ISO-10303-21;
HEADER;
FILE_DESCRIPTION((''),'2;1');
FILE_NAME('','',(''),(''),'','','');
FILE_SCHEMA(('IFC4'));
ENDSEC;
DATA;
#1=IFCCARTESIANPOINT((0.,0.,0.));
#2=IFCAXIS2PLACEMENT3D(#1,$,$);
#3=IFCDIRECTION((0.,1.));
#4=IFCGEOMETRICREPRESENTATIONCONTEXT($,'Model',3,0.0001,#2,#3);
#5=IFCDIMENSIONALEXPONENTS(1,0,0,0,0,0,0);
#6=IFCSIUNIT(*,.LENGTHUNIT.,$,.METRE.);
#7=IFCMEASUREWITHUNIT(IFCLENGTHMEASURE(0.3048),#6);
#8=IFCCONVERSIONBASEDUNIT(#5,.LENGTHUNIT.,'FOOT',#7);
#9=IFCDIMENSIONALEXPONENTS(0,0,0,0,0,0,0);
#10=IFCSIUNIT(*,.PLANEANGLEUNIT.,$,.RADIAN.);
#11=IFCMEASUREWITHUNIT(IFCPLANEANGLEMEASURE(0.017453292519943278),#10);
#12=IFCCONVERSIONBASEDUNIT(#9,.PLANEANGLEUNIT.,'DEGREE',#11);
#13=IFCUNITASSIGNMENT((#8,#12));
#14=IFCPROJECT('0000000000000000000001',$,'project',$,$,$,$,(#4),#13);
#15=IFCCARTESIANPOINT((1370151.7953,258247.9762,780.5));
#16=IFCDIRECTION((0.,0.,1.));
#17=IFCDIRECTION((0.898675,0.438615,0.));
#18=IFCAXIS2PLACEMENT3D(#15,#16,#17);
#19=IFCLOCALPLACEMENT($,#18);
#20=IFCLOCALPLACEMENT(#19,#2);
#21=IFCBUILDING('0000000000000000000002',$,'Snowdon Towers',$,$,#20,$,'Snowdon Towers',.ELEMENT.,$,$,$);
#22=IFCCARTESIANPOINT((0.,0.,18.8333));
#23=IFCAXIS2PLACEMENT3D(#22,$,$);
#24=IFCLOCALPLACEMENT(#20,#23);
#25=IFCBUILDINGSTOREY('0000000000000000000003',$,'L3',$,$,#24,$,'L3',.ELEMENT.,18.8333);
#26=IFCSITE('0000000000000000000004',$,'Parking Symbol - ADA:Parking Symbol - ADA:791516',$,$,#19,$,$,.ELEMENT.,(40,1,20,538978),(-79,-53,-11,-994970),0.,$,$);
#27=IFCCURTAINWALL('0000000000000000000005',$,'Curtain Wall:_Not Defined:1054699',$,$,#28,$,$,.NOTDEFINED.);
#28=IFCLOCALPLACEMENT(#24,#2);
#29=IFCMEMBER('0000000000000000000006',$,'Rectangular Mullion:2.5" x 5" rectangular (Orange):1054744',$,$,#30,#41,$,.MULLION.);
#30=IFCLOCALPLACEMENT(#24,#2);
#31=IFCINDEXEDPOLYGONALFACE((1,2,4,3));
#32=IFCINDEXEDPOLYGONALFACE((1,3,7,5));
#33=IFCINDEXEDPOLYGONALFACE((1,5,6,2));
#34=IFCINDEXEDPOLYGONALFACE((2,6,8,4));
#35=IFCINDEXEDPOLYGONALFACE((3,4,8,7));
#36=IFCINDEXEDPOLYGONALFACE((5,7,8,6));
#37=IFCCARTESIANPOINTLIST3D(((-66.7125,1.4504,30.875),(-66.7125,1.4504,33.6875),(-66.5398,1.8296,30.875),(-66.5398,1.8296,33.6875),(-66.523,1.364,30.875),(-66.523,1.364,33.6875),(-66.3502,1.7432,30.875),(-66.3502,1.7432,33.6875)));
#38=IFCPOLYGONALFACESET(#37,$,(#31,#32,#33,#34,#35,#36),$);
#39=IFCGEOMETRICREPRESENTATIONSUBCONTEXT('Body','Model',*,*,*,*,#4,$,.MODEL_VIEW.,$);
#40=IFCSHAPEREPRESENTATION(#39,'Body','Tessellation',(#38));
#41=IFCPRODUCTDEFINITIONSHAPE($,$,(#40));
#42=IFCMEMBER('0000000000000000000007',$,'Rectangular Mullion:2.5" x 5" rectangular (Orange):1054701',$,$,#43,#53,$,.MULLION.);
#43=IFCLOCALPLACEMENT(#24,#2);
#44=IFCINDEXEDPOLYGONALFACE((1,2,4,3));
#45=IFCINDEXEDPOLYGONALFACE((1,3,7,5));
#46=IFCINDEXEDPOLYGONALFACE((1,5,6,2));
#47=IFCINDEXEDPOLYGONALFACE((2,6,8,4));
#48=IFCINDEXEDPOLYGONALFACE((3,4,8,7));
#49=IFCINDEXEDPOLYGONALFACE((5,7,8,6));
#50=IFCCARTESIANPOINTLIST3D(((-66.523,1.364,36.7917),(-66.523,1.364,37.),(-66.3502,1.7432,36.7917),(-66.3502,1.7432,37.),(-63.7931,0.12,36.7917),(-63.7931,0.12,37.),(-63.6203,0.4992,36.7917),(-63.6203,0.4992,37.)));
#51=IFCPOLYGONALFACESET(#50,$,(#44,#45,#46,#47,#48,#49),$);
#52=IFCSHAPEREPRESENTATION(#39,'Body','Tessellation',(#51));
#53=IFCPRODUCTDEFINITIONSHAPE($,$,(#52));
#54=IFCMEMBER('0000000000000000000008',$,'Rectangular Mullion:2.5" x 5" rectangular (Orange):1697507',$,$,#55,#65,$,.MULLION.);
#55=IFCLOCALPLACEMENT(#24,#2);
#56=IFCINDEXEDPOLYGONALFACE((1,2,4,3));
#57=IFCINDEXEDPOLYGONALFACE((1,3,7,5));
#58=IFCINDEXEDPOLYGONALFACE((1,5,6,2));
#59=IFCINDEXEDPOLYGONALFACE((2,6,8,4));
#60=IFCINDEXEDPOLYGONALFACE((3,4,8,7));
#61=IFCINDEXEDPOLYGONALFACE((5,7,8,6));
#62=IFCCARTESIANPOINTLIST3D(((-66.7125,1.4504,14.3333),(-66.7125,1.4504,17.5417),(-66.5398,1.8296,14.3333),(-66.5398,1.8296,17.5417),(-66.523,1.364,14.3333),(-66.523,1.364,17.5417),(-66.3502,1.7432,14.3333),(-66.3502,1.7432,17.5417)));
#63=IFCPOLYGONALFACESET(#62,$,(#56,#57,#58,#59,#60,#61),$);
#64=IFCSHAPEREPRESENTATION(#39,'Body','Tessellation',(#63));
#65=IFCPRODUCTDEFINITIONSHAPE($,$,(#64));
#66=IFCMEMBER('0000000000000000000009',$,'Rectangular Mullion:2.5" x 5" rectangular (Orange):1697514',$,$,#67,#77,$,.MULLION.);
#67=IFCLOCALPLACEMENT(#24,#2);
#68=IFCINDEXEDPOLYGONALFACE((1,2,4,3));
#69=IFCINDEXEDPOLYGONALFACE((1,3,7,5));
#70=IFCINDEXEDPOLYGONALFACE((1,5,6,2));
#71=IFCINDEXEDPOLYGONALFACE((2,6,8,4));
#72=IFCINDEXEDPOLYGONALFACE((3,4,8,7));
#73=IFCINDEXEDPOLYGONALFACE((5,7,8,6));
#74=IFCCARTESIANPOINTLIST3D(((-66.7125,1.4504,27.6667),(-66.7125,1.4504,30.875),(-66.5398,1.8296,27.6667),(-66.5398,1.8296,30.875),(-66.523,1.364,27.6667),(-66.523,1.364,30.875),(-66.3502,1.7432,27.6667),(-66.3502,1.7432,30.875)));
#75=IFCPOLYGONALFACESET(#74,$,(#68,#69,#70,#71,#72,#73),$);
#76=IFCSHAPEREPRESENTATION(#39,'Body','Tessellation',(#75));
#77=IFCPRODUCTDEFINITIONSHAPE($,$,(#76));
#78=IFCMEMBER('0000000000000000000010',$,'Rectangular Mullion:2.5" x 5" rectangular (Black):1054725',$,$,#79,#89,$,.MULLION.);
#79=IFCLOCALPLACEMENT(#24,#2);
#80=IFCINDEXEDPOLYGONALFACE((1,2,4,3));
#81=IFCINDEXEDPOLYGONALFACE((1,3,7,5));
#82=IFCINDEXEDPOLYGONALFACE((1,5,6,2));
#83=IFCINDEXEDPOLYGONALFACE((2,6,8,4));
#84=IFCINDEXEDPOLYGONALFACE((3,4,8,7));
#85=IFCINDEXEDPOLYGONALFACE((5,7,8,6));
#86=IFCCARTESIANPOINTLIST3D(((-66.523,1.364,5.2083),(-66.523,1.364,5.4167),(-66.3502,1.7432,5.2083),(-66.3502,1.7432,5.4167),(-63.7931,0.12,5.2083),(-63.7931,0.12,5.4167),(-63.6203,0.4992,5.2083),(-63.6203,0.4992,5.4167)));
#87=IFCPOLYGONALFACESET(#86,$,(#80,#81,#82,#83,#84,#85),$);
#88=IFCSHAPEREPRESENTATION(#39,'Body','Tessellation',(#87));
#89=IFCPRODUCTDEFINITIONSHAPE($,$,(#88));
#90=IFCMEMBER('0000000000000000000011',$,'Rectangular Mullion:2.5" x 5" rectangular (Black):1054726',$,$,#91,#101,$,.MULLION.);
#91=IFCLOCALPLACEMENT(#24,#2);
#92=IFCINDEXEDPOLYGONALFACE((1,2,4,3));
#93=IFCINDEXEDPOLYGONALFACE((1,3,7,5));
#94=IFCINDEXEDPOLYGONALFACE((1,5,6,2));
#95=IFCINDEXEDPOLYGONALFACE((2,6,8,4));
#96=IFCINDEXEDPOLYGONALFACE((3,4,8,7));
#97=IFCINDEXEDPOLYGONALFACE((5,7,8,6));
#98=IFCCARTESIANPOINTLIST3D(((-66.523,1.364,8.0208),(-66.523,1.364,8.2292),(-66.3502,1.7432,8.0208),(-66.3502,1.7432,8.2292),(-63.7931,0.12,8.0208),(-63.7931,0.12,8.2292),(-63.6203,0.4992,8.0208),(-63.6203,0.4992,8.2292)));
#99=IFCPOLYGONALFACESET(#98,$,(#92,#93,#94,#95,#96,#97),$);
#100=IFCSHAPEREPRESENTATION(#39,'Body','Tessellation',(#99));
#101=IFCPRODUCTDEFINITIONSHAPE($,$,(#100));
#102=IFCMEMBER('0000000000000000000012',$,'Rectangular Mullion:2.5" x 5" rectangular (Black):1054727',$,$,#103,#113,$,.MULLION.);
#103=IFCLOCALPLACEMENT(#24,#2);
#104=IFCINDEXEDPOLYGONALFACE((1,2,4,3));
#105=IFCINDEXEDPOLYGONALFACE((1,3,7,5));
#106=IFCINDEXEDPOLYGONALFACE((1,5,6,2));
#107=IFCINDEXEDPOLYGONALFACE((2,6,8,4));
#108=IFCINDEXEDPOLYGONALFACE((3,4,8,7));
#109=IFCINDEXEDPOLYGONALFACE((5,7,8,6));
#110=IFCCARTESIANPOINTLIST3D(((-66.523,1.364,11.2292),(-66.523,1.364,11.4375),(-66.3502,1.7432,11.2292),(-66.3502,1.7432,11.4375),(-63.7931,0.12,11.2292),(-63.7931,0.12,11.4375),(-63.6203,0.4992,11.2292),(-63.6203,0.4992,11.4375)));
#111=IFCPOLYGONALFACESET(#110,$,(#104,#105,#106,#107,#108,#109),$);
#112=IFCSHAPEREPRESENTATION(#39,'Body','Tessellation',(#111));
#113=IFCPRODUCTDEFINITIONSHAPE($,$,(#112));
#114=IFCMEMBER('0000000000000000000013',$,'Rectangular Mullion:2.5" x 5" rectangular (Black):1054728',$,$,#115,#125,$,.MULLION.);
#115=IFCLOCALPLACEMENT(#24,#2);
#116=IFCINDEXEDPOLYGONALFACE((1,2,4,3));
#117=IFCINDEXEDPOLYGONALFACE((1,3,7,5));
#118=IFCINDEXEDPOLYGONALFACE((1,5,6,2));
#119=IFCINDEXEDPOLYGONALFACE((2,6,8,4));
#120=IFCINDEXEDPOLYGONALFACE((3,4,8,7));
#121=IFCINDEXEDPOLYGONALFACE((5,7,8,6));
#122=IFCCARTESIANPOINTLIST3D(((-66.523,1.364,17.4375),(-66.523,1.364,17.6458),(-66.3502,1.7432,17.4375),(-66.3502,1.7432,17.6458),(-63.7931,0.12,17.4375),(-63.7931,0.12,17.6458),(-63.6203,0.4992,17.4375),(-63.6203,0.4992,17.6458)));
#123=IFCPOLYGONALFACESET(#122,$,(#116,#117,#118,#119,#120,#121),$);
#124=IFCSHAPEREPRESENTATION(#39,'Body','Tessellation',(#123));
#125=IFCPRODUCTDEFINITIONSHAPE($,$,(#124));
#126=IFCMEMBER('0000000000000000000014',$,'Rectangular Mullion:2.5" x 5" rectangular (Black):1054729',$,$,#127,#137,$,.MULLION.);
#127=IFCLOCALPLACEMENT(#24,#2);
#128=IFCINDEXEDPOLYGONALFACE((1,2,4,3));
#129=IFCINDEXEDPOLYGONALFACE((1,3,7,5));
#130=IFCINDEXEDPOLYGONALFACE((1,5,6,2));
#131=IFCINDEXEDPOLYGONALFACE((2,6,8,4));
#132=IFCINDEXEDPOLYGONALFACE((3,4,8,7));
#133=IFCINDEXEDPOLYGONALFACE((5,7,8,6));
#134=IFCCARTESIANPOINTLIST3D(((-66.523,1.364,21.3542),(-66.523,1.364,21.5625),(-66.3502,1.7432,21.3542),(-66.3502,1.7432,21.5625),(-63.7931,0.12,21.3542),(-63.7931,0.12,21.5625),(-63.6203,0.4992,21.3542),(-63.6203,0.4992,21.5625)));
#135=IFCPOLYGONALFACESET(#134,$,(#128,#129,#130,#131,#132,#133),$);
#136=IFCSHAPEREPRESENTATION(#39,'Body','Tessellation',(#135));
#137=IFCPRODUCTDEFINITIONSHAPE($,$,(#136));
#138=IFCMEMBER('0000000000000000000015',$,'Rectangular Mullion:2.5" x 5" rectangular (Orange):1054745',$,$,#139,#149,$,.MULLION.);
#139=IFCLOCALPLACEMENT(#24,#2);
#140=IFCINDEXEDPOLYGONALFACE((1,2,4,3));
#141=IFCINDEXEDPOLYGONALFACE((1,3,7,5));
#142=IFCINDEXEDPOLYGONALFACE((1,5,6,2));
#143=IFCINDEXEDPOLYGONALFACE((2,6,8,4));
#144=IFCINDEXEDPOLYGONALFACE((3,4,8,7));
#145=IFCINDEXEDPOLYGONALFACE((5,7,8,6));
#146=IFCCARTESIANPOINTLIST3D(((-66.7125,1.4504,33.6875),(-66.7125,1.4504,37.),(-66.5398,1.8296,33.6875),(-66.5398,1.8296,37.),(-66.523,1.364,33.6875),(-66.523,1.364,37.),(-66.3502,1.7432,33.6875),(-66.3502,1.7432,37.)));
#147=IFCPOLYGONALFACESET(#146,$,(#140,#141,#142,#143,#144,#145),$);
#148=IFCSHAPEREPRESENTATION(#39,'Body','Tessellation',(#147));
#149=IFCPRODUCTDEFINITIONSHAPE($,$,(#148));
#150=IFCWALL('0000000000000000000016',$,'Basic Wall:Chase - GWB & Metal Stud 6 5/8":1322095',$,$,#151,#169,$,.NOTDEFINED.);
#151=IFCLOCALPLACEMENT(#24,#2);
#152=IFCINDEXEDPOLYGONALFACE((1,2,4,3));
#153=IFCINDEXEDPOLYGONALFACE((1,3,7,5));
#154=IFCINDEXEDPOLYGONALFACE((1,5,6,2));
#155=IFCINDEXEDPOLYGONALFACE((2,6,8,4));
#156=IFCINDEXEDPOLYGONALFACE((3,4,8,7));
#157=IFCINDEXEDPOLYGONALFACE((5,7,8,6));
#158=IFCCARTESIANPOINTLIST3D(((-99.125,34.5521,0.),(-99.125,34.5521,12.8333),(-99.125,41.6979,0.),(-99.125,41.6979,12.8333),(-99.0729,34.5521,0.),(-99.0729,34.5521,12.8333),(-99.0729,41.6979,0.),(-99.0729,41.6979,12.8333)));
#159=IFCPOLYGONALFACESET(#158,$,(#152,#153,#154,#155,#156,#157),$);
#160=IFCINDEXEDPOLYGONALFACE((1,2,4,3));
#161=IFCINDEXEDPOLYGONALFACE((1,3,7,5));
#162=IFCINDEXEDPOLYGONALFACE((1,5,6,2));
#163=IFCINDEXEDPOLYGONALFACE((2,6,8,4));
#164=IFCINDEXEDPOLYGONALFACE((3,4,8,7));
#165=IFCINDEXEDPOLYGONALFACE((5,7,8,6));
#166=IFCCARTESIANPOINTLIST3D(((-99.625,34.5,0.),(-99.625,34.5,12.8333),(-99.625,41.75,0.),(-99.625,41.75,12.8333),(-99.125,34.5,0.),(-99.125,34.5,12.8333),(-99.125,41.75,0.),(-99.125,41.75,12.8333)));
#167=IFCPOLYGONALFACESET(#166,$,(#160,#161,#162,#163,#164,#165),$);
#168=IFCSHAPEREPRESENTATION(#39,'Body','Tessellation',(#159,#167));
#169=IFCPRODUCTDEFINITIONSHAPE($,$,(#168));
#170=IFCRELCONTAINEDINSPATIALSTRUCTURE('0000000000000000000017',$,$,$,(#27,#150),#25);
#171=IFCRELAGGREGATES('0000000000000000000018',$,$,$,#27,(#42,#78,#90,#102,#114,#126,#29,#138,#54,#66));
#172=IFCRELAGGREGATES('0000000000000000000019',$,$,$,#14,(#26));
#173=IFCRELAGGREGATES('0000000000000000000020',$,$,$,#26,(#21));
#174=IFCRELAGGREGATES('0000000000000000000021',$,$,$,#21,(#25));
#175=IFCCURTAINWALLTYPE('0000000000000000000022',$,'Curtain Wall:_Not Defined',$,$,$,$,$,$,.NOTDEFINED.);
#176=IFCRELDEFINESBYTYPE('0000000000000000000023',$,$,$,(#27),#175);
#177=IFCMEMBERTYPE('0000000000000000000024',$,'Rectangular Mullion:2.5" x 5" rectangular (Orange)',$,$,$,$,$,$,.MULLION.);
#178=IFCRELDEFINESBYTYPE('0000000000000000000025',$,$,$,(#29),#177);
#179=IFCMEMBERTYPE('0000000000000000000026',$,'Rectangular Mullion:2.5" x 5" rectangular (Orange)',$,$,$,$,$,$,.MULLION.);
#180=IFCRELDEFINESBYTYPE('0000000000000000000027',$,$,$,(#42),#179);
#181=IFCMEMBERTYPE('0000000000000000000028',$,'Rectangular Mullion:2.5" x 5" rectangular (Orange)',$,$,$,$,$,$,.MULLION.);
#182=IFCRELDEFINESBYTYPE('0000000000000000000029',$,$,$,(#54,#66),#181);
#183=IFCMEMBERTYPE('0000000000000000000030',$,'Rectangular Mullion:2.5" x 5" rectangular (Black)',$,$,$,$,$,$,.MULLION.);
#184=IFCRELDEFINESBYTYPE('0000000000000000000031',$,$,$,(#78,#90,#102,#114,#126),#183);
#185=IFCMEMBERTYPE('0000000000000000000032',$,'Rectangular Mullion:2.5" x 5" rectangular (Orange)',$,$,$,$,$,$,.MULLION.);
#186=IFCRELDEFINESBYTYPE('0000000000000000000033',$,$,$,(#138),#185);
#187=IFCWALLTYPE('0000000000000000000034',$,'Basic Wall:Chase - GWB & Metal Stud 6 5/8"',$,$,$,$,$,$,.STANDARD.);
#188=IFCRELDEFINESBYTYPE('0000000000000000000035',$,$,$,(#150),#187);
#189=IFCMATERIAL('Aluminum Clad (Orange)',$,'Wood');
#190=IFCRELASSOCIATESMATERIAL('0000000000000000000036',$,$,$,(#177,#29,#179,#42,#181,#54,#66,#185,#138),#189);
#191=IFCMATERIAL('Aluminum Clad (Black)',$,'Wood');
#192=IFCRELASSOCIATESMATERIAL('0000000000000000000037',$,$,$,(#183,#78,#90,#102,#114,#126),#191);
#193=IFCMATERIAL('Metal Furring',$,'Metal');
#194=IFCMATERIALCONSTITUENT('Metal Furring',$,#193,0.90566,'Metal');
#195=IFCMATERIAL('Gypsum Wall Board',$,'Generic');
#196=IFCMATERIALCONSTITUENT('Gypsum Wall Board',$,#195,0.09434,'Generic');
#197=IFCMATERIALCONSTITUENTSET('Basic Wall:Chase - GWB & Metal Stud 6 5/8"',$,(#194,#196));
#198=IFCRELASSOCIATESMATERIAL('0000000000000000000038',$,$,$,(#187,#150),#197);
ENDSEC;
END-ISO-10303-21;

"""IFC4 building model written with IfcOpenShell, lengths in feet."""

from ifc_helpers import new_model, entity, si_unit, converted_unit, direction, frame, origin, place, context, subcontext, project, spatial, indexed_curve, outline, extrude, source, transform, mapped, material, constituent, constituent_set, type_object, type_shapes, element, aggregate, save


model = new_model("IFC4")

# Units and contexts
model_context = context("Model", 3, precision=0.0001, world=origin(), true_north=direction((0.0, 1.0)))
body_context = subcontext(model_context, "Body", "Model", "MODEL_VIEW")
ifc_project = project(units=[converted_unit("LENGTHUNIT", "FOOT", entity("IfcLengthMeasure", 0.3048), si_unit("LENGTHUNIT", "METRE"), dimensions=[1, 0, 0, 0, 0, 0, 0]), converted_unit("PLANEANGLEUNIT", "DEGREE", entity("IfcPlaneAngleMeasure", 0.017453292519943278), si_unit("PLANEANGLEUNIT", "RADIAN"), dimensions=[0, 0, 0, 0, 0, 0, 0])], contexts=[model_context])

# Site, building, storey
site_placement = place(None, frame((1370151.7953, 258247.9762, 780.5), z_axis=(0.0, 0.0, 1.0), x_axis=(0.898675, 0.438615, 0.0)))
site = spatial("IfcSite", under=ifc_project, at=site_placement, Name="Parking Symbol - ADA:Parking Symbol - ADA:791516", CompositionType="ELEMENT", RefLatitude=(40, 1, 20, 538978), RefLongitude=(-79, -53, -11, -994970), RefElevation=0.0)
building_placement = place(site_placement, origin())
building = spatial("IfcBuilding", under=site, at=building_placement, Name="Snowdon Towers", LongName="Snowdon Towers", CompositionType="ELEMENT")
storey_placement = place(building_placement, frame((0.0, 0.0, 18.8333)))
storey = spatial("IfcBuildingStorey", under=building, at=storey_placement, Name="L3", LongName="L3", CompositionType="ELEMENT", Elevation=18.8333)

# Curtain wall, members
curtain_wall_type = type_object("IfcCurtainWallType", Name="Curtain Wall:_Not Defined", PredefinedType="NOTDEFINED")
curtain_wall_placement = place(storey_placement, frame((0.0, 0.0, -18.8333)))
curtain_wall = element("IfcCurtainWall", 1, at=curtain_wall_placement, inside=storey, type_object=curtain_wall_type, Name="Curtain Wall:_Not Defined:1054699", PredefinedType="NOTDEFINED")
ifc_material_1 = material(Name="Aluminum Clad (Orange)", Category="Wood")
member_type_1 = type_object("IfcMemberType", Name="Rectangular Mullion:2.5\" x 5\" rectangular (Orange)", PredefinedType="MULLION", material=ifc_material_1)
shared_shape_1 = source(origin(), body_context, "Body", "SweptSolid", [
    extrude(outline(indexed_curve([(-0.1042, -0.2083), (0.1042, -0.2083), (0.1042, 0.2083), (-0.1042, 0.2083), (-0.1042, -0.2083)], self_intersect=False)), frame((-0.1042, 0.0, -2.8125), z_axis=(0.0, 0.0, 1.0), x_axis=(-1.0, 0.0, 0.0)), (0.0, 0.0, 1.0), 2.8125),
])
type_shapes(member_type_1, [shared_shape_1])
member_1_placement = place(curtain_wall_placement, frame((-66.6262, 1.64, 49.7083), z_axis=(0.0, 0.0, -1.0), x_axis=(-0.909972, 0.414671, 0.0)))
member_1 = element("IfcMember", 2, at=member_1_placement, type_object=member_type_1, material=ifc_material_1, Name="Rectangular Mullion:2.5\" x 5\" rectangular (Orange):1054744", PredefinedType="MULLION", context=body_context, shape_type="MappedRepresentation", body=[
    mapped(shared_shape_1, transform((0.0, 0.0, 0.0), scale=1.0)),
])
member_type_2 = type_object("IfcMemberType", Name="Rectangular Mullion:2.5\" x 5\" rectangular (Orange)", PredefinedType="MULLION", material=ifc_material_1)
shared_shape_2 = source(origin(), body_context, "Body", "SweptSolid", [
    extrude(outline(indexed_curve([(-0.1042, -0.2083), (0.1042, -0.2083), (0.1042, 0.2083), (-0.1042, 0.2083), (-0.1042, -0.2083)], self_intersect=False)), frame((-0.1042, 0.0, -3.0), z_axis=(0.0, 0.0, 1.0), x_axis=(-1.0, 0.0, 0.0)), (0.0, 0.0, 1.0), 3.0),
])
type_shapes(member_type_2, [shared_shape_2])
member_2_placement = place(curtain_wall_placement, frame((-66.4366, 1.5536, 55.8333), z_axis=(-0.909972, 0.414671, 0.0), x_axis=(0.0, 0.0, 1.0)))
member_2 = element("IfcMember", 3, at=member_2_placement, type_object=member_type_2, material=ifc_material_1, Name="Rectangular Mullion:2.5\" x 5\" rectangular (Orange):1054701", PredefinedType="MULLION", context=body_context, shape_type="MappedRepresentation", body=[
    mapped(shared_shape_2, transform((0.0, 0.0, 0.0), scale=1.0)),
])
member_type_3 = type_object("IfcMemberType", Name="Rectangular Mullion:2.5\" x 5\" rectangular (Orange)", PredefinedType="MULLION", material=ifc_material_1)
shared_shape_3 = source(origin(), body_context, "Body", "SweptSolid", [
    extrude(outline(indexed_curve([(-0.1042, -0.2083), (0.1042, -0.2083), (0.1042, 0.2083), (-0.1042, 0.2083), (-0.1042, -0.2083)], self_intersect=False)), frame((-0.1042, 0.0, -3.2083), z_axis=(0.0, 0.0, 1.0), x_axis=(-1.0, 0.0, 0.0)), (0.0, 0.0, 1.0), 3.2083),
])
type_shapes(member_type_3, [shared_shape_3])
member_3_placement = place(curtain_wall_placement, frame((-66.6262, 1.64, 33.1667), z_axis=(0.0, 0.0, -1.0), x_axis=(-0.909972, 0.414671, 0.0)))
member_3 = element("IfcMember", 4, at=member_3_placement, type_object=member_type_3, material=ifc_material_1, Name="Rectangular Mullion:2.5\" x 5\" rectangular (Orange):1697507", PredefinedType="MULLION", context=body_context, shape_type="MappedRepresentation", body=[
    mapped(shared_shape_3, transform((0.0, 0.0, 0.0), scale=1.0)),
])
member_4_placement = place(curtain_wall_placement, frame((-66.6262, 1.64, 46.5), z_axis=(0.0, 0.0, -1.0), x_axis=(-0.909972, 0.414671, 0.0)))
member_4 = element("IfcMember", 5, at=member_4_placement, type_object=member_type_3, material=ifc_material_1, Name="Rectangular Mullion:2.5\" x 5\" rectangular (Orange):1697514", PredefinedType="MULLION", context=body_context, shape_type="MappedRepresentation", body=[
    mapped(shared_shape_3, transform((0.0, 0.0, 0.0), scale=1.0)),
])
ifc_material_2 = material(Name="Aluminum Clad (Black)", Category="Wood")
member_type_4 = type_object("IfcMemberType", Name="Rectangular Mullion:2.5\" x 5\" rectangular (Black)", PredefinedType="MULLION", material=ifc_material_2)
shared_shape_4 = source(origin(), body_context, "Body", "SweptSolid", [
    extrude(outline(indexed_curve([(-0.1042, -0.2083), (0.1042, -0.2083), (0.1042, 0.2083), (-0.1042, 0.2083), (-0.1042, -0.2083)], self_intersect=False)), frame((0.0, 0.0, -3.0), z_axis=(0.0, 0.0, 1.0), x_axis=(-1.0, 0.0, 0.0)), (0.0, 0.0, 1.0), 3.0),
])
type_shapes(member_type_4, [shared_shape_4])
member_5_placement = place(curtain_wall_placement, frame((-66.4366, 1.5536, 24.1458), z_axis=(-0.909972, 0.414671, 0.0), x_axis=(0.0, 0.0, 1.0)))
member_5 = element("IfcMember", 6, at=member_5_placement, type_object=member_type_4, material=ifc_material_2, Name="Rectangular Mullion:2.5\" x 5\" rectangular (Black):1054725", PredefinedType="MULLION", context=body_context, shape_type="MappedRepresentation", body=[
    mapped(shared_shape_4, transform((0.0, 0.0, 0.0), scale=1.0)),
])
member_6_placement = place(curtain_wall_placement, frame((-66.4366, 1.5536, 26.9583), z_axis=(-0.909972, 0.414671, 0.0), x_axis=(0.0, 0.0, 1.0)))
member_6 = element("IfcMember", 7, at=member_6_placement, type_object=member_type_4, material=ifc_material_2, Name="Rectangular Mullion:2.5\" x 5\" rectangular (Black):1054726", PredefinedType="MULLION", context=body_context, shape_type="MappedRepresentation", body=[
    mapped(shared_shape_4, transform((0.0, 0.0, 0.0), scale=1.0)),
])
member_7_placement = place(curtain_wall_placement, frame((-66.4366, 1.5536, 30.1667), z_axis=(-0.909972, 0.414671, 0.0), x_axis=(0.0, 0.0, 1.0)))
member_7 = element("IfcMember", 8, at=member_7_placement, type_object=member_type_4, material=ifc_material_2, Name="Rectangular Mullion:2.5\" x 5\" rectangular (Black):1054727", PredefinedType="MULLION", context=body_context, shape_type="MappedRepresentation", body=[
    mapped(shared_shape_4, transform((0.0, 0.0, 0.0), scale=1.0)),
])
member_8_placement = place(curtain_wall_placement, frame((-66.4366, 1.5536, 36.375), z_axis=(-0.909972, 0.414671, 0.0), x_axis=(0.0, 0.0, 1.0)))
member_8 = element("IfcMember", 9, at=member_8_placement, type_object=member_type_4, material=ifc_material_2, Name="Rectangular Mullion:2.5\" x 5\" rectangular (Black):1054728", PredefinedType="MULLION", context=body_context, shape_type="MappedRepresentation", body=[
    mapped(shared_shape_4, transform((0.0, 0.0, 0.0), scale=1.0)),
])
member_9_placement = place(curtain_wall_placement, frame((-66.4366, 1.5536, 40.2917), z_axis=(-0.909972, 0.414671, 0.0), x_axis=(0.0, 0.0, 1.0)))
member_9 = element("IfcMember", 10, at=member_9_placement, type_object=member_type_4, material=ifc_material_2, Name="Rectangular Mullion:2.5\" x 5\" rectangular (Black):1054729", PredefinedType="MULLION", context=body_context, shape_type="MappedRepresentation", body=[
    mapped(shared_shape_4, transform((0.0, 0.0, 0.0), scale=1.0)),
])
member_type_5 = type_object("IfcMemberType", Name="Rectangular Mullion:2.5\" x 5\" rectangular (Orange)", PredefinedType="MULLION", material=ifc_material_1)
shared_shape_5 = source(origin(), body_context, "Body", "SweptSolid", [
    extrude(outline(indexed_curve([(-0.1042, -0.2083), (0.1042, -0.2083), (0.1042, 0.2083), (-0.1042, 0.2083), (-0.1042, -0.2083)], self_intersect=False)), frame((-0.1042, 0.0, -3.3125), z_axis=(0.0, 0.0, 1.0), x_axis=(-1.0, 0.0, 0.0)), (0.0, 0.0, 1.0), 3.3125),
])
type_shapes(member_type_5, [shared_shape_5])
member_10_placement = place(curtain_wall_placement, frame((-66.6262, 1.64, 52.5208), z_axis=(0.0, 0.0, -1.0), x_axis=(-0.909972, 0.414671, 0.0)))
member_10 = element("IfcMember", 11, at=member_10_placement, type_object=member_type_5, material=ifc_material_1, Name="Rectangular Mullion:2.5\" x 5\" rectangular (Orange):1054745", PredefinedType="MULLION", context=body_context, shape_type="MappedRepresentation", body=[
    mapped(shared_shape_5, transform((0.0, 0.0, 0.0), scale=1.0)),
])
aggregate(curtain_wall, [member_2, member_5, member_6, member_7, member_8, member_9, member_1, member_10, member_3, member_4])

# Wall
ifc_material_3 = material(Name="Metal Furring", Category="Metal")
ifc_material_4 = material(Name="Gypsum Wall Board", Category="Generic")
ifc_constituent_1 = constituent(ifc_material_3, Name="Metal Furring", Category="Metal", fraction=0.90566)
ifc_constituent_2 = constituent(ifc_material_4, Name="Gypsum Wall Board", Category="Generic", fraction=0.09434)
ifc_constituent_set_1 = constituent_set(constituents=[ifc_constituent_1, ifc_constituent_2], Name="Basic Wall:Chase - GWB & Metal Stud 6 5/8\"")
wall_type_1 = type_object("IfcWallType", Name="Basic Wall:Chase - GWB & Metal Stud 6 5/8\"", PredefinedType="STANDARD", material=ifc_constituent_set_1)
wall_1_placement = place(storey_placement, frame((-99.349, 41.6979, 0.0), z_axis=(0.0, 0.0, 1.0), x_axis=(0.0, -1.0, 0.0)))
element("IfcWall", 12, at=wall_1_placement, inside=storey, type_object=wall_type_1, material=ifc_constituent_set_1, Name="Basic Wall:Chase - GWB & Metal Stud 6 5/8\":1322095", PredefinedType="NOTDEFINED", context=body_context, shape_type="SweptSolid", body=[
    extrude(outline(indexed_curve([(-0.026, -3.5729), (0.026, -3.5729), (0.026, 3.5729), (-0.026, 3.5729), (-0.026, -3.5729)], self_intersect=False)), frame((3.5729, 0.25, 0.0), z_axis=(0.0, 0.0, 1.0), x_axis=(0.0, -1.0, 0.0)), (0.0, 0.0, 1.0), 12.8333),
    extrude(outline(indexed_curve([(-0.25, -3.625), (0.25, -3.625), (0.25, 3.625), (-0.25, 3.625), (-0.25, -3.625)], self_intersect=False)), frame((3.5729, -0.026, 0.0), z_axis=(0.0, 0.0, 1.0), x_axis=(0.0, -1.0, 0.0)), (0.0, 0.0, 1.0), 12.8333),
])

save(model, "model.ifc")
